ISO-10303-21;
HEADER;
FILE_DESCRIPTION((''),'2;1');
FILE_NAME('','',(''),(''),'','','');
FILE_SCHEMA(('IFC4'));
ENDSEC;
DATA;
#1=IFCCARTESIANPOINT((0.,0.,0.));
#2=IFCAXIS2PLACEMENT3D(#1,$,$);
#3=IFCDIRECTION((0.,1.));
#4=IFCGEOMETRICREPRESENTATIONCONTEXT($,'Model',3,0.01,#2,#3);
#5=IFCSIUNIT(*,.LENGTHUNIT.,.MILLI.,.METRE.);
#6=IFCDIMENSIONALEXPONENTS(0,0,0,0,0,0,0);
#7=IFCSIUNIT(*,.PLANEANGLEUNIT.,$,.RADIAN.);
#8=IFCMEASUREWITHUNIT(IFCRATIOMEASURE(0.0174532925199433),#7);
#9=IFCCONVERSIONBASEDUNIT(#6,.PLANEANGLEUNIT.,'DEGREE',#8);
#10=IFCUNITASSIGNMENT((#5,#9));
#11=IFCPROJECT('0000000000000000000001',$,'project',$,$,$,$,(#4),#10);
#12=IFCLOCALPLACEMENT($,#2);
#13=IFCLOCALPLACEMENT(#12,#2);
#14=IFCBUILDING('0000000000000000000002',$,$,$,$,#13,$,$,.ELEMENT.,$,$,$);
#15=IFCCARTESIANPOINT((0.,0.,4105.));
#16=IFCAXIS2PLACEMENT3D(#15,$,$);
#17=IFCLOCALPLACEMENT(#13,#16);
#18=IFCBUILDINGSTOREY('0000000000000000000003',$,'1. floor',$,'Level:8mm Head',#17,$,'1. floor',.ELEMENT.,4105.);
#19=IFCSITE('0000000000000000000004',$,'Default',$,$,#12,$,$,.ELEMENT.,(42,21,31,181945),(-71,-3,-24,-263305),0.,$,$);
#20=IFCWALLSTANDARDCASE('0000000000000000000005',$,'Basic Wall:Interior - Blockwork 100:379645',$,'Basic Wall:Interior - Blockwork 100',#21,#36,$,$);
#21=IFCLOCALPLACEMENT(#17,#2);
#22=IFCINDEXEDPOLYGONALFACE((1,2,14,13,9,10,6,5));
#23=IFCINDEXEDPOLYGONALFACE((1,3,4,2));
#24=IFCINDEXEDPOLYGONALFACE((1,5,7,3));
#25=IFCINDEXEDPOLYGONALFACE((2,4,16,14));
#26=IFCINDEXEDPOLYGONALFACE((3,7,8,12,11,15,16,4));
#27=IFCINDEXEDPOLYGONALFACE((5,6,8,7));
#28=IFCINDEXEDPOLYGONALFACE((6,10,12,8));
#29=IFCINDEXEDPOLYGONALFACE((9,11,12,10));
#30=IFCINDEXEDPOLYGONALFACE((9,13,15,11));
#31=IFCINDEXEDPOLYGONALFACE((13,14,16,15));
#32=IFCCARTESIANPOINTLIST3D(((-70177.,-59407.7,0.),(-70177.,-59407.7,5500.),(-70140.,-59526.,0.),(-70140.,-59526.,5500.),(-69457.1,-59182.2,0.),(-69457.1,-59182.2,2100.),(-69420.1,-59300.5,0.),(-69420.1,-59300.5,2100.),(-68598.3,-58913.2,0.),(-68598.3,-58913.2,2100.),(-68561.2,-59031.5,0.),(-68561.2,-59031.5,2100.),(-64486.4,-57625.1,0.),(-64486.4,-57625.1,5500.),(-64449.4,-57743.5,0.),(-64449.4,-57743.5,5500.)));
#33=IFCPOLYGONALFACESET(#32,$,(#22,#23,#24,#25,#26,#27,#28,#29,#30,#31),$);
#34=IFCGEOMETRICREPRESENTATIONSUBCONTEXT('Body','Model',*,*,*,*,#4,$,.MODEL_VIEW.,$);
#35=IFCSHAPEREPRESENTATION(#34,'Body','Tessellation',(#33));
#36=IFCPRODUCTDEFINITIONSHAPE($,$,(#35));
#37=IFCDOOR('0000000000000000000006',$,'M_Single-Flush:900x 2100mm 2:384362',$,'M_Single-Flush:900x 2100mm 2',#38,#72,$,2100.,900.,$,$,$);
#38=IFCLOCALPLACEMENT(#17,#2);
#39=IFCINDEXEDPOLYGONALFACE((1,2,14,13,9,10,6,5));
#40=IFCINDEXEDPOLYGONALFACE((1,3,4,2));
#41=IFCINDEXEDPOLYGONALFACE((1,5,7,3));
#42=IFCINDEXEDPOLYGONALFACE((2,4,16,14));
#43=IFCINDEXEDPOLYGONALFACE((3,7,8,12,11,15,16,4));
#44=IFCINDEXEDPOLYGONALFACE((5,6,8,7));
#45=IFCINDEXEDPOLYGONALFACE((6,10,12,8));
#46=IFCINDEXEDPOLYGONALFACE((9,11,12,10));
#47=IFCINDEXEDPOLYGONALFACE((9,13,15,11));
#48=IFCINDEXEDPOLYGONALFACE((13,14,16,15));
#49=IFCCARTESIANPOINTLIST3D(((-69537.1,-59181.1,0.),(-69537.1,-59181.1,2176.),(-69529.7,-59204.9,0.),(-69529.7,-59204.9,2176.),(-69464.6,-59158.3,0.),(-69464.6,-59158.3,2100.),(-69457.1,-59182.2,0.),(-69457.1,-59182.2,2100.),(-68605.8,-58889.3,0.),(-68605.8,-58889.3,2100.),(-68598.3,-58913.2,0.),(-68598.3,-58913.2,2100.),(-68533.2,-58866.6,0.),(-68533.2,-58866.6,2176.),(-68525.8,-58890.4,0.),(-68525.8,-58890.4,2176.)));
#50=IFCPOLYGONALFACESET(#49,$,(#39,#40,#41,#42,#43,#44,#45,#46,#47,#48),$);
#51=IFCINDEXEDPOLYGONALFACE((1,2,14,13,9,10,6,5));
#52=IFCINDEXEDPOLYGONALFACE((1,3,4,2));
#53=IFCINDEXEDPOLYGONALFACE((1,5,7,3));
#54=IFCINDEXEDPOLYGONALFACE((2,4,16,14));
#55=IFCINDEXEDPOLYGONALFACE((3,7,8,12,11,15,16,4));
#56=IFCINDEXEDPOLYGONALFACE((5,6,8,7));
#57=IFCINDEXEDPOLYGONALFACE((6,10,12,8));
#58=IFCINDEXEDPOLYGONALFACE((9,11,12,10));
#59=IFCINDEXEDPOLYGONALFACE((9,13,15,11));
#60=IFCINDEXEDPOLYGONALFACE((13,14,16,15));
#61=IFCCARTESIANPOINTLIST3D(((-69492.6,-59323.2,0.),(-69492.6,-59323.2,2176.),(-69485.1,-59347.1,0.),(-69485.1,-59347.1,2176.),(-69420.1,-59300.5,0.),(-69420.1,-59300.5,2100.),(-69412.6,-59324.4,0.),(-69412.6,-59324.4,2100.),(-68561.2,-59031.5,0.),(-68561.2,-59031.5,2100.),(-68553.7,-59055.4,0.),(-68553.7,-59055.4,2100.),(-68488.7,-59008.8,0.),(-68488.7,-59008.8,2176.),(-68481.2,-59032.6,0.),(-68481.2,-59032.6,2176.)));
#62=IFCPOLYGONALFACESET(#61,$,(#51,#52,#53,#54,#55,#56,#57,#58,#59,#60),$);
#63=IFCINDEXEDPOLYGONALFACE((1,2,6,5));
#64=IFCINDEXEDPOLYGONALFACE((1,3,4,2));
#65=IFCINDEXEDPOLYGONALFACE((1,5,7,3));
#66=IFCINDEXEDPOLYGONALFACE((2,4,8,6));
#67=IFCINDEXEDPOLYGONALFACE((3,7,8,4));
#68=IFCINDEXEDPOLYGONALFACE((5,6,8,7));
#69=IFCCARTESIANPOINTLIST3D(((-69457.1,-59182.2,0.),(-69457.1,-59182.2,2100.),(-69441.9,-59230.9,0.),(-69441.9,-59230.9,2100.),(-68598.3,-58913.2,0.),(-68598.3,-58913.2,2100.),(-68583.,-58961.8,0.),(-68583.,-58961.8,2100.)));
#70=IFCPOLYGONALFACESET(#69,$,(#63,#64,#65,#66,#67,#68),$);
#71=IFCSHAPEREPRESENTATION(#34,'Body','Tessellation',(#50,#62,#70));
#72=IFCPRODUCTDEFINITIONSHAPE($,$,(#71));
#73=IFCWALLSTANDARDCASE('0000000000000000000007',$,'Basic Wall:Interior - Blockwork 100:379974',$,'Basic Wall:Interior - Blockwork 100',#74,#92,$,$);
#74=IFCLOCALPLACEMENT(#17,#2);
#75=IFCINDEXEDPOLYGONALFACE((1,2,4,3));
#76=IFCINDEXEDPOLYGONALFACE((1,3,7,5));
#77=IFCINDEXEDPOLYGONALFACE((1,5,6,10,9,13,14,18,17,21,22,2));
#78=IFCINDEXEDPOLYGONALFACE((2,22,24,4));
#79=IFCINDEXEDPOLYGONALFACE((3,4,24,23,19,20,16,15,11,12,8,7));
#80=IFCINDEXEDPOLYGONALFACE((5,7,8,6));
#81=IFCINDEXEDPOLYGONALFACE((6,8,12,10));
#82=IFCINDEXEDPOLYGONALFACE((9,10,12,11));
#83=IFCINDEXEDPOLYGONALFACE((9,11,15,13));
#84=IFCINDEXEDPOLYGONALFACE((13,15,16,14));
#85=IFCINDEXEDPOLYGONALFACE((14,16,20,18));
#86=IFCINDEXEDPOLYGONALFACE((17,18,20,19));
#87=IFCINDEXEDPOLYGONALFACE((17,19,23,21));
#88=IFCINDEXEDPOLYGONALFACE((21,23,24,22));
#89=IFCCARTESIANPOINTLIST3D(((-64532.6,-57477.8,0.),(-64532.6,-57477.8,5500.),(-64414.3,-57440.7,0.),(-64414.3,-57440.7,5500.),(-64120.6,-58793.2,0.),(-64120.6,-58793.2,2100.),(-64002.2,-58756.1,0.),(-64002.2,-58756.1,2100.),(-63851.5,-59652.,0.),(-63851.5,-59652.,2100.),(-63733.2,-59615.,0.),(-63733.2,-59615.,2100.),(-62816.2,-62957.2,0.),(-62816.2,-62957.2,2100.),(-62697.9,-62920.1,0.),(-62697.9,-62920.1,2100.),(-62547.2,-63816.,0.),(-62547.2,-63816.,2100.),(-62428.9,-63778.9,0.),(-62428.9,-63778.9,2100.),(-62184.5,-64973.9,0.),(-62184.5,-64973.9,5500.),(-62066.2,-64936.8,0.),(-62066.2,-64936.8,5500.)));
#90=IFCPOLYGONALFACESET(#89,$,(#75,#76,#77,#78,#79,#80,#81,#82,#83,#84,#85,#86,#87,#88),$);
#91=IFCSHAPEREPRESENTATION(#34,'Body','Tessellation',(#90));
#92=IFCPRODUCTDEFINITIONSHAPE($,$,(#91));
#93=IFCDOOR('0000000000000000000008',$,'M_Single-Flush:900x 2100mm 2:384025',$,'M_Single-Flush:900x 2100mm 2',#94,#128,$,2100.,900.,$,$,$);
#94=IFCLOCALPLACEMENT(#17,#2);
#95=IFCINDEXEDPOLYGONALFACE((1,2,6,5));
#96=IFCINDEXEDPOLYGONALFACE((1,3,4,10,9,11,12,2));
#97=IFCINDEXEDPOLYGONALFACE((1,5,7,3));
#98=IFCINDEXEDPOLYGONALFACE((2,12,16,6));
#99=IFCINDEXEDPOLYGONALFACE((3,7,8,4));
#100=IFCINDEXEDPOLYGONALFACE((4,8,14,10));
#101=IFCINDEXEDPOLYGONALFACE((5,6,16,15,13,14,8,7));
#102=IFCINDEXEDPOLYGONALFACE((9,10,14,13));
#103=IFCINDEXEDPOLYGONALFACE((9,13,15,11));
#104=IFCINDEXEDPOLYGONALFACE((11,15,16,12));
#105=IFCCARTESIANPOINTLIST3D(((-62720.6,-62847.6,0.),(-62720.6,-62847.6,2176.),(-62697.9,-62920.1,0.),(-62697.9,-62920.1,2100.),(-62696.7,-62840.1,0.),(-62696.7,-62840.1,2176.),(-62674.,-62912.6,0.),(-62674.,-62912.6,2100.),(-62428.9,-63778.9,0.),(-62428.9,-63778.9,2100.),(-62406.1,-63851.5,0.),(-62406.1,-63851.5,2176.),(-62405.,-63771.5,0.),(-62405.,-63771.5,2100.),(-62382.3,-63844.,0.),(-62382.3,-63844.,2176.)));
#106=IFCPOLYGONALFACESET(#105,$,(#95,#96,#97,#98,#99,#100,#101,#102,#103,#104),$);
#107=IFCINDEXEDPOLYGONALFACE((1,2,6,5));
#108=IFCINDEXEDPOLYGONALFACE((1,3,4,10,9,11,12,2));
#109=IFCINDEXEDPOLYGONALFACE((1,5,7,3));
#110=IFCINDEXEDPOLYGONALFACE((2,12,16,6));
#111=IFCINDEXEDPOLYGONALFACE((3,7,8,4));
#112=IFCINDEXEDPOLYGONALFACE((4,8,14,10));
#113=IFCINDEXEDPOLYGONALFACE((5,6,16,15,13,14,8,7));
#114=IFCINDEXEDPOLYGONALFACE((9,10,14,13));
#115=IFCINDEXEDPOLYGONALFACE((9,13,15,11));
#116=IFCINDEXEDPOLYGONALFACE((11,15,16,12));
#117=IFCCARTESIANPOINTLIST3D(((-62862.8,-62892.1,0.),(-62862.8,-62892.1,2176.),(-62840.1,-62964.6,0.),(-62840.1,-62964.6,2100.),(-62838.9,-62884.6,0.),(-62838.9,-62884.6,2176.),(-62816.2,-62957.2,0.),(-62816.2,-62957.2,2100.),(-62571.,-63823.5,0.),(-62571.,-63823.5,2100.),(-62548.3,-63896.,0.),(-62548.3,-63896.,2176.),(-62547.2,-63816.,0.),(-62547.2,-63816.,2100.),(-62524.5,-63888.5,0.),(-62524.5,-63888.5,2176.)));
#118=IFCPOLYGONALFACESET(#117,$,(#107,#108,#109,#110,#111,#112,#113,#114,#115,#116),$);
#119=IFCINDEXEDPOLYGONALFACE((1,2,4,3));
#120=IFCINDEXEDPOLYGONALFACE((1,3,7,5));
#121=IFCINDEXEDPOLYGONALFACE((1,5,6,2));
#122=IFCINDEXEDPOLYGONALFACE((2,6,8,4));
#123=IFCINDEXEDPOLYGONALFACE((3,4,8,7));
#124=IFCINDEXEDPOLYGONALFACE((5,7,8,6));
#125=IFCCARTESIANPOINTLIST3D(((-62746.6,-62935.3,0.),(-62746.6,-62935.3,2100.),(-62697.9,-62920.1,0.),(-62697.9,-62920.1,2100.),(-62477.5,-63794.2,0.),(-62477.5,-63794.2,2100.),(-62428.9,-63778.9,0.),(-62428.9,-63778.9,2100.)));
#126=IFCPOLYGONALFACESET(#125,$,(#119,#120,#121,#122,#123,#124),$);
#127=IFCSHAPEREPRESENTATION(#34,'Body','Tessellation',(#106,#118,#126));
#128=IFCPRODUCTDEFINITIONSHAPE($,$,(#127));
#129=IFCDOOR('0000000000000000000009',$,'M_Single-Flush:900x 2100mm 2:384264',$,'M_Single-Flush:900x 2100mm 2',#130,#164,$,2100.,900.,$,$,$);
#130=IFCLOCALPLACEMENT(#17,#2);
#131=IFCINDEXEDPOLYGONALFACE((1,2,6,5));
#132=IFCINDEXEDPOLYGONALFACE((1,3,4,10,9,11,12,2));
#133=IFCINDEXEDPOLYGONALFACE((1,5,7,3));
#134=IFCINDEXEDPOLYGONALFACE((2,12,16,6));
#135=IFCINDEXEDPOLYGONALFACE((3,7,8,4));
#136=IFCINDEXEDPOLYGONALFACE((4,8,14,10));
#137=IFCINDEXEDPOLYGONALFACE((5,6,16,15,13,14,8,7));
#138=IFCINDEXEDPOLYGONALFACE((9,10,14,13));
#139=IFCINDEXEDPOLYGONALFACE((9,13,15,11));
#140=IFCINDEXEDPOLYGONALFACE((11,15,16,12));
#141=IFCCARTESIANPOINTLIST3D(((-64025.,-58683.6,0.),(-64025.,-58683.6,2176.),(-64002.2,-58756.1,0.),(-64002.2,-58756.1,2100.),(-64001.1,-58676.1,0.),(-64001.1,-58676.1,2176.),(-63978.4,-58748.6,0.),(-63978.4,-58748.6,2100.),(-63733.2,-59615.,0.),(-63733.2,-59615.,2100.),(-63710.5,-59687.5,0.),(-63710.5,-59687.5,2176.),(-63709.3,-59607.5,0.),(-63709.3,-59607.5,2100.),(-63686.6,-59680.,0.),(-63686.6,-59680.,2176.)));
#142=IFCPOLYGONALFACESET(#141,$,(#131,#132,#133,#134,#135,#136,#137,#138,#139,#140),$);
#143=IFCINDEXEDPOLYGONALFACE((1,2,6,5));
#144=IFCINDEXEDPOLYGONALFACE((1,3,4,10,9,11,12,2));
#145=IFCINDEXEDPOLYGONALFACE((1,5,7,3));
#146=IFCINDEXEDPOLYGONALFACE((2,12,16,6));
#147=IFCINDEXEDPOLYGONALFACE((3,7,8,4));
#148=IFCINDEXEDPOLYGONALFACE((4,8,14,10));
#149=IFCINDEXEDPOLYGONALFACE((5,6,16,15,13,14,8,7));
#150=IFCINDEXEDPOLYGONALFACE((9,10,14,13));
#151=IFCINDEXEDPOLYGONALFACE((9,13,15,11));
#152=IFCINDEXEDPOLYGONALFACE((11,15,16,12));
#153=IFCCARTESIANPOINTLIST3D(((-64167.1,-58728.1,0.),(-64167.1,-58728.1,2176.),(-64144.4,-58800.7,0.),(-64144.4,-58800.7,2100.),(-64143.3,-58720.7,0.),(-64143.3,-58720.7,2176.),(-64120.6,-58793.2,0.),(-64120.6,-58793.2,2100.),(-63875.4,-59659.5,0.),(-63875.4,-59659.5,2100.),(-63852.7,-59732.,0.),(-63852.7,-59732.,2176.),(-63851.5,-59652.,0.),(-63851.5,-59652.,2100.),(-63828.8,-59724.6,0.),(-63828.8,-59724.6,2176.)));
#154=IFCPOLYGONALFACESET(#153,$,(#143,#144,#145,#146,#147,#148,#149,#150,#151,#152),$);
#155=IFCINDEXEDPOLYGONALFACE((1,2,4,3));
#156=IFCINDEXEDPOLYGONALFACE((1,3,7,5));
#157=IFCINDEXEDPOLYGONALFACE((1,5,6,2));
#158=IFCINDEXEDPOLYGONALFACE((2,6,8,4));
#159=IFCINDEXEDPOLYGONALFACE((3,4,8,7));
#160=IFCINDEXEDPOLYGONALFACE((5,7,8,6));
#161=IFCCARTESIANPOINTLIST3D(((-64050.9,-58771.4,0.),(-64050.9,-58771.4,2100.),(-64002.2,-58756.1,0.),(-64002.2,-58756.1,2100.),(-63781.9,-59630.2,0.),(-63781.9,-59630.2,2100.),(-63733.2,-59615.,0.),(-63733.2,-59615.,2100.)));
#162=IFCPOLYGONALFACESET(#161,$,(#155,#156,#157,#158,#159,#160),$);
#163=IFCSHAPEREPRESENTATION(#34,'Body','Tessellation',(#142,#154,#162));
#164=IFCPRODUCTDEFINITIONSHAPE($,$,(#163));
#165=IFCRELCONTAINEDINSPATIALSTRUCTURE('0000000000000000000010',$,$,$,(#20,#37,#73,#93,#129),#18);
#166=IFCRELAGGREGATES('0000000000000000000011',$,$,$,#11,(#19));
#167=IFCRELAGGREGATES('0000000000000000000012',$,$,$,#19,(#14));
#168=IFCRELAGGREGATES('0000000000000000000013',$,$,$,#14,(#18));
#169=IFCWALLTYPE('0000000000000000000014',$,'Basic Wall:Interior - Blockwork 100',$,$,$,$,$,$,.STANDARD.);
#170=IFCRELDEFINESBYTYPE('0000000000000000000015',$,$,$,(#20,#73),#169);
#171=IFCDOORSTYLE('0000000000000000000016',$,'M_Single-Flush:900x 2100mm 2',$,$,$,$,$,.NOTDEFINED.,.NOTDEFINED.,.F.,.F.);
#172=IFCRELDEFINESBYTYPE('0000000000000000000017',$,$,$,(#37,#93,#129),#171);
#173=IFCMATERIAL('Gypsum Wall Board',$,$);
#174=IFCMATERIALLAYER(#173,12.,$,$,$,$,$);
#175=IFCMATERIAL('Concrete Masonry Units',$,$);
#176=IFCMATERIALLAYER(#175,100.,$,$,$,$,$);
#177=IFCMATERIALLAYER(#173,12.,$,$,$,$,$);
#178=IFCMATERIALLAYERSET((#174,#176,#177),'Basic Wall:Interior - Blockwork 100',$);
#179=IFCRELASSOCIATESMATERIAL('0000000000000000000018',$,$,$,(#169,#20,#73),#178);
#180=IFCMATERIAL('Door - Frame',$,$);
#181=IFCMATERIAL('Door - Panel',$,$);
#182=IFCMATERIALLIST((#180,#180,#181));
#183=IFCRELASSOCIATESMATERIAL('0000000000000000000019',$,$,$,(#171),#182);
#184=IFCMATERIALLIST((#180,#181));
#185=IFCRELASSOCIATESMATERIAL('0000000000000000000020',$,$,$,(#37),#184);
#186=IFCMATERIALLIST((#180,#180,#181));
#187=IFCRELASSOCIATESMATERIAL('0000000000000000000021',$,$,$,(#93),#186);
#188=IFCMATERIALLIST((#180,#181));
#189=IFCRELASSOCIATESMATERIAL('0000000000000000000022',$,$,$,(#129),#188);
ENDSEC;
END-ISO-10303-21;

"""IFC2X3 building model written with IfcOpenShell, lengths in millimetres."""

from ifc_helpers import new_model, entity, si_unit, converted_unit, direction, frame, frame_2d, origin, origin_2d_with_axis, place, context, subcontext, project, spatial, polyline, rectangle, outline, extrude, source, transform, mapped, material, material_list, layer, layer_set, layer_usage, type_object, type_shapes, element, fill, save


model = new_model("IFC2X3")

# Units and contexts
model_context = context("Model", 3, precision=0.01, world=origin(), true_north=direction((0.0, 1.0)))
body_context = subcontext(model_context, "Body", "Model", "MODEL_VIEW")
ifc_project = project(units=[si_unit("LENGTHUNIT", "METRE", prefix="MILLI"), converted_unit("PLANEANGLEUNIT", "DEGREE", entity("IfcRatioMeasure", 0.0174532925199433), si_unit("PLANEANGLEUNIT", "RADIAN"), dimensions=[0, 0, 0, 0, 0, 0, 0])], contexts=[model_context])

# Site, building, storey
site_placement = place(None, origin())
site = spatial("IfcSite", under=ifc_project, at=site_placement, Name="Default", CompositionType="ELEMENT", RefLatitude=(42, 21, 31, 181945), RefLongitude=(-71, -3, -24, -263305), RefElevation=0.0)
building_placement = place(site_placement, origin())
building = spatial("IfcBuilding", under=site, at=building_placement, CompositionType="ELEMENT")
storey_placement = place(building_placement, frame((0.0, 0.0, 4105.0)))
storey = spatial("IfcBuildingStorey", under=building, at=storey_placement, Name="1. floor", ObjectType="Level:8mm Head", LongName="1. floor", CompositionType="ELEMENT", Elevation=4105.0)

# Wall, opening, door
ifc_material_1 = material(Name="Gypsum Wall Board")
ifc_layer_1 = layer(ifc_material_1, 12.0)
ifc_material_2 = material(Name="Concrete Masonry Units")
ifc_layer_2 = layer(ifc_material_2, 100.0)
ifc_layer_3 = layer(ifc_material_1, 12.0)
ifc_layer_set_1 = layer_set([ifc_layer_1, ifc_layer_2, ifc_layer_3], Name="Basic Wall:Interior - Blockwork 100")
ifc_layer_usage_1 = layer_usage(ifc_layer_set_1, "AXIS2", "NEGATIVE", 62.0)
wall_type_1 = type_object("IfcWallType", Name="Basic Wall:Interior - Blockwork 100", PredefinedType="STANDARD", material=ifc_layer_set_1)
wall_1_placement = place(storey_placement, frame((-64467.9, -57684.3, 0.0), z_axis=(0.0, 0.0, 1.0), x_axis=(-0.954277, -0.298924, 0.0)))
wall_1 = element("IfcWallStandardCase", 1, at=wall_1_placement, inside=storey, type_object=wall_type_1, material=ifc_layer_usage_1, Name="Basic Wall:Interior - Blockwork 100:379645", ObjectType="Basic Wall:Interior - Blockwork 100", context=body_context, shape_type="SweptSolid", body=[
    extrude(rectangle(XDim=5963.2, YDim=124.0, at=frame_2d((2981.6, 0.0), x_axis=(-1.0, 0.0))), origin(), (0.0, 0.0, 1.0), 5500.0),
])
opening_1_placement = place(wall_1_placement, frame((5208.9, 62.0, 0.0)))
opening_1 = element("IfcOpeningElement", 2, at=opening_1_placement, cuts=wall_1, ObjectType="Opening", context=body_context, shape_type="SweptSolid", body=[
    extrude(rectangle(XDim=900.0, YDim=2100.0, at=frame_2d((1050.0, 450.0), x_axis=(0.0, 1.0))), frame((0.0, 0.0, 0.0), z_axis=(0.0, -1.0, 0.0), x_axis=(0.0, 0.0, 1.0)), (0.0, 0.0, 1.0), 124.0),
])
ifc_material_3 = material(Name="Door - Frame")
ifc_material_4 = material(Name="Door - Panel")
ifc_material_list_1 = material_list([ifc_material_3, ifc_material_4])
ifc_material_list_2 = material_list([ifc_material_3, ifc_material_3, ifc_material_4])
door_style_1 = type_object("IfcDoorStyle", Name="M_Single-Flush:900x 2100mm 2", ConstructionType="NOTDEFINED", OperationType="NOTDEFINED", ParameterTakesPrecedence=False, Sizeable=False, material=ifc_material_list_2)
shared_shape_1 = source(origin(), body_context, "Body", "SweptSolid", [
    extrude(outline(polyline([(-526.0, -1107.0), (526.0, -1107.0), (526.0, 1069.0), (450.0, 1069.0), (450.0, -1031.0), (-450.0, -1031.0), (-450.0, 1069.0), (-526.0, 1069.0), (-526.0, -1107.0)])), frame((450.0, 124.0, 1069.0), z_axis=(0.0, 1.0, 0.0), x_axis=(1.0, 0.0, 0.0)), (0.0, 0.0, 1.0), 25.0),
    extrude(outline(polyline([(-1107.0, -526.0), (1069.0, -526.0), (1069.0, -450.0), (-1031.0, -450.0), (-1031.0, 450.0), (1069.0, 450.0), (1069.0, 526.0), (-1107.0, 526.0), (-1107.0, -526.0)])), frame((450.0, -25.0, 1069.0), z_axis=(0.0, 1.0, 0.0), x_axis=(0.0, 0.0, -1.0)), (0.0, 0.0, 1.0), 25.0),
    extrude(rectangle(XDim=51.0, YDim=900.0, at=origin_2d_with_axis()), frame((450.0, 98.5, 0.0), z_axis=(0.0, 0.0, 1.0), x_axis=(0.0, 1.0, 0.0)), (0.0, 0.0, 1.0), 2100.0),
])
type_shapes(door_style_1, [shared_shape_1])
door_1_placement = place(opening_1_placement, frame((0.0, 0.0, 0.0), z_axis=(0.0, 0.0, 1.0), x_axis=(-1.0, 0.0, 0.0)))
door_1 = element("IfcDoor", 3, at=door_1_placement, inside=storey, type_object=door_style_1, material=ifc_material_list_1, Name="M_Single-Flush:900x 2100mm 2:384362", ObjectType="M_Single-Flush:900x 2100mm 2", OverallHeight=2100.0, OverallWidth=900.0, context=body_context, shape_type="MappedRepresentation", body=[
    mapped(shared_shape_1, transform((0.0, 0.0, 0.0), scale=1.0)),
])
fill(opening_1, door_1)

# Wall, openings, doors
ifc_layer_usage_2 = layer_usage(ifc_layer_set_1, "AXIS2", "NEGATIVE", 62.0)
wall_2_placement = place(storey_placement, frame((-64473.4, -57459.3, 0.0), z_axis=(0.0, 0.0, 1.0), x_axis=(0.298924, -0.954277, 0.0)))
wall_2 = element("IfcWallStandardCase", 4, at=wall_2_placement, inside=storey, type_object=wall_type_1, material=ifc_layer_usage_2, Name="Basic Wall:Interior - Blockwork 100:379974", ObjectType="Basic Wall:Interior - Blockwork 100", context=body_context, shape_type="SweptSolid", body=[
    extrude(rectangle(XDim=7855.2, YDim=124.0, at=frame_2d((3927.6, 0.0), x_axis=(-1.0, 0.0))), origin(), (0.0, 0.0, 1.0), 5500.0),
])
opening_2_placement = place(wall_2_placement, frame((5741.9, -62.0, 0.0)))
opening_2 = element("IfcOpeningElement", 5, at=opening_2_placement, cuts=wall_2, ObjectType="Opening", context=body_context, shape_type="SweptSolid", body=[
    extrude(rectangle(XDim=900.0, YDim=2100.0, at=frame_2d((1050.0, 450.0), x_axis=(0.0, 1.0))), frame((0.0, 0.0, 0.0), z_axis=(0.0, 1.0, 0.0), x_axis=(0.0, 0.0, 1.0)), (0.0, 0.0, 1.0), 124.0),
])
opening_3_placement = place(wall_2_placement, frame((1378.4, -62.0, 0.0)))
opening_3 = element("IfcOpeningElement", 6, at=opening_3_placement, cuts=wall_2, ObjectType="Opening", context=body_context, shape_type="SweptSolid", body=[
    extrude(rectangle(XDim=900.0, YDim=2100.0, at=frame_2d((1050.0, 450.0), x_axis=(0.0, 1.0))), frame((0.0, 0.0, 0.0), z_axis=(0.0, 1.0, 0.0), x_axis=(0.0, 0.0, 1.0)), (0.0, 0.0, 1.0), 124.0),
])
ifc_material_list_3 = material_list([ifc_material_3, ifc_material_3, ifc_material_4])
door_2_placement = place(opening_2_placement, origin())
door_2 = element("IfcDoor", 7, at=door_2_placement, inside=storey, type_object=door_style_1, material=ifc_material_list_3, Name="M_Single-Flush:900x 2100mm 2:384025", ObjectType="M_Single-Flush:900x 2100mm 2", OverallHeight=2100.0, OverallWidth=900.0, context=body_context, shape_type="MappedRepresentation", body=[
    mapped(shared_shape_1, transform((0.0, 0.0, 0.0), scale=1.0)),
])
fill(opening_2, door_2)
ifc_material_list_4 = material_list([ifc_material_3, ifc_material_4])
door_3_placement = place(opening_3_placement, origin())
door_3 = element("IfcDoor", 8, at=door_3_placement, inside=storey, type_object=door_style_1, material=ifc_material_list_4, Name="M_Single-Flush:900x 2100mm 2:384264", ObjectType="M_Single-Flush:900x 2100mm 2", OverallHeight=2100.0, OverallWidth=900.0, context=body_context, shape_type="MappedRepresentation", body=[
    mapped(shared_shape_1, transform((0.0, 0.0, 0.0), scale=1.0)),
])
fill(opening_3, door_3)

save(model, "model.ifc")
